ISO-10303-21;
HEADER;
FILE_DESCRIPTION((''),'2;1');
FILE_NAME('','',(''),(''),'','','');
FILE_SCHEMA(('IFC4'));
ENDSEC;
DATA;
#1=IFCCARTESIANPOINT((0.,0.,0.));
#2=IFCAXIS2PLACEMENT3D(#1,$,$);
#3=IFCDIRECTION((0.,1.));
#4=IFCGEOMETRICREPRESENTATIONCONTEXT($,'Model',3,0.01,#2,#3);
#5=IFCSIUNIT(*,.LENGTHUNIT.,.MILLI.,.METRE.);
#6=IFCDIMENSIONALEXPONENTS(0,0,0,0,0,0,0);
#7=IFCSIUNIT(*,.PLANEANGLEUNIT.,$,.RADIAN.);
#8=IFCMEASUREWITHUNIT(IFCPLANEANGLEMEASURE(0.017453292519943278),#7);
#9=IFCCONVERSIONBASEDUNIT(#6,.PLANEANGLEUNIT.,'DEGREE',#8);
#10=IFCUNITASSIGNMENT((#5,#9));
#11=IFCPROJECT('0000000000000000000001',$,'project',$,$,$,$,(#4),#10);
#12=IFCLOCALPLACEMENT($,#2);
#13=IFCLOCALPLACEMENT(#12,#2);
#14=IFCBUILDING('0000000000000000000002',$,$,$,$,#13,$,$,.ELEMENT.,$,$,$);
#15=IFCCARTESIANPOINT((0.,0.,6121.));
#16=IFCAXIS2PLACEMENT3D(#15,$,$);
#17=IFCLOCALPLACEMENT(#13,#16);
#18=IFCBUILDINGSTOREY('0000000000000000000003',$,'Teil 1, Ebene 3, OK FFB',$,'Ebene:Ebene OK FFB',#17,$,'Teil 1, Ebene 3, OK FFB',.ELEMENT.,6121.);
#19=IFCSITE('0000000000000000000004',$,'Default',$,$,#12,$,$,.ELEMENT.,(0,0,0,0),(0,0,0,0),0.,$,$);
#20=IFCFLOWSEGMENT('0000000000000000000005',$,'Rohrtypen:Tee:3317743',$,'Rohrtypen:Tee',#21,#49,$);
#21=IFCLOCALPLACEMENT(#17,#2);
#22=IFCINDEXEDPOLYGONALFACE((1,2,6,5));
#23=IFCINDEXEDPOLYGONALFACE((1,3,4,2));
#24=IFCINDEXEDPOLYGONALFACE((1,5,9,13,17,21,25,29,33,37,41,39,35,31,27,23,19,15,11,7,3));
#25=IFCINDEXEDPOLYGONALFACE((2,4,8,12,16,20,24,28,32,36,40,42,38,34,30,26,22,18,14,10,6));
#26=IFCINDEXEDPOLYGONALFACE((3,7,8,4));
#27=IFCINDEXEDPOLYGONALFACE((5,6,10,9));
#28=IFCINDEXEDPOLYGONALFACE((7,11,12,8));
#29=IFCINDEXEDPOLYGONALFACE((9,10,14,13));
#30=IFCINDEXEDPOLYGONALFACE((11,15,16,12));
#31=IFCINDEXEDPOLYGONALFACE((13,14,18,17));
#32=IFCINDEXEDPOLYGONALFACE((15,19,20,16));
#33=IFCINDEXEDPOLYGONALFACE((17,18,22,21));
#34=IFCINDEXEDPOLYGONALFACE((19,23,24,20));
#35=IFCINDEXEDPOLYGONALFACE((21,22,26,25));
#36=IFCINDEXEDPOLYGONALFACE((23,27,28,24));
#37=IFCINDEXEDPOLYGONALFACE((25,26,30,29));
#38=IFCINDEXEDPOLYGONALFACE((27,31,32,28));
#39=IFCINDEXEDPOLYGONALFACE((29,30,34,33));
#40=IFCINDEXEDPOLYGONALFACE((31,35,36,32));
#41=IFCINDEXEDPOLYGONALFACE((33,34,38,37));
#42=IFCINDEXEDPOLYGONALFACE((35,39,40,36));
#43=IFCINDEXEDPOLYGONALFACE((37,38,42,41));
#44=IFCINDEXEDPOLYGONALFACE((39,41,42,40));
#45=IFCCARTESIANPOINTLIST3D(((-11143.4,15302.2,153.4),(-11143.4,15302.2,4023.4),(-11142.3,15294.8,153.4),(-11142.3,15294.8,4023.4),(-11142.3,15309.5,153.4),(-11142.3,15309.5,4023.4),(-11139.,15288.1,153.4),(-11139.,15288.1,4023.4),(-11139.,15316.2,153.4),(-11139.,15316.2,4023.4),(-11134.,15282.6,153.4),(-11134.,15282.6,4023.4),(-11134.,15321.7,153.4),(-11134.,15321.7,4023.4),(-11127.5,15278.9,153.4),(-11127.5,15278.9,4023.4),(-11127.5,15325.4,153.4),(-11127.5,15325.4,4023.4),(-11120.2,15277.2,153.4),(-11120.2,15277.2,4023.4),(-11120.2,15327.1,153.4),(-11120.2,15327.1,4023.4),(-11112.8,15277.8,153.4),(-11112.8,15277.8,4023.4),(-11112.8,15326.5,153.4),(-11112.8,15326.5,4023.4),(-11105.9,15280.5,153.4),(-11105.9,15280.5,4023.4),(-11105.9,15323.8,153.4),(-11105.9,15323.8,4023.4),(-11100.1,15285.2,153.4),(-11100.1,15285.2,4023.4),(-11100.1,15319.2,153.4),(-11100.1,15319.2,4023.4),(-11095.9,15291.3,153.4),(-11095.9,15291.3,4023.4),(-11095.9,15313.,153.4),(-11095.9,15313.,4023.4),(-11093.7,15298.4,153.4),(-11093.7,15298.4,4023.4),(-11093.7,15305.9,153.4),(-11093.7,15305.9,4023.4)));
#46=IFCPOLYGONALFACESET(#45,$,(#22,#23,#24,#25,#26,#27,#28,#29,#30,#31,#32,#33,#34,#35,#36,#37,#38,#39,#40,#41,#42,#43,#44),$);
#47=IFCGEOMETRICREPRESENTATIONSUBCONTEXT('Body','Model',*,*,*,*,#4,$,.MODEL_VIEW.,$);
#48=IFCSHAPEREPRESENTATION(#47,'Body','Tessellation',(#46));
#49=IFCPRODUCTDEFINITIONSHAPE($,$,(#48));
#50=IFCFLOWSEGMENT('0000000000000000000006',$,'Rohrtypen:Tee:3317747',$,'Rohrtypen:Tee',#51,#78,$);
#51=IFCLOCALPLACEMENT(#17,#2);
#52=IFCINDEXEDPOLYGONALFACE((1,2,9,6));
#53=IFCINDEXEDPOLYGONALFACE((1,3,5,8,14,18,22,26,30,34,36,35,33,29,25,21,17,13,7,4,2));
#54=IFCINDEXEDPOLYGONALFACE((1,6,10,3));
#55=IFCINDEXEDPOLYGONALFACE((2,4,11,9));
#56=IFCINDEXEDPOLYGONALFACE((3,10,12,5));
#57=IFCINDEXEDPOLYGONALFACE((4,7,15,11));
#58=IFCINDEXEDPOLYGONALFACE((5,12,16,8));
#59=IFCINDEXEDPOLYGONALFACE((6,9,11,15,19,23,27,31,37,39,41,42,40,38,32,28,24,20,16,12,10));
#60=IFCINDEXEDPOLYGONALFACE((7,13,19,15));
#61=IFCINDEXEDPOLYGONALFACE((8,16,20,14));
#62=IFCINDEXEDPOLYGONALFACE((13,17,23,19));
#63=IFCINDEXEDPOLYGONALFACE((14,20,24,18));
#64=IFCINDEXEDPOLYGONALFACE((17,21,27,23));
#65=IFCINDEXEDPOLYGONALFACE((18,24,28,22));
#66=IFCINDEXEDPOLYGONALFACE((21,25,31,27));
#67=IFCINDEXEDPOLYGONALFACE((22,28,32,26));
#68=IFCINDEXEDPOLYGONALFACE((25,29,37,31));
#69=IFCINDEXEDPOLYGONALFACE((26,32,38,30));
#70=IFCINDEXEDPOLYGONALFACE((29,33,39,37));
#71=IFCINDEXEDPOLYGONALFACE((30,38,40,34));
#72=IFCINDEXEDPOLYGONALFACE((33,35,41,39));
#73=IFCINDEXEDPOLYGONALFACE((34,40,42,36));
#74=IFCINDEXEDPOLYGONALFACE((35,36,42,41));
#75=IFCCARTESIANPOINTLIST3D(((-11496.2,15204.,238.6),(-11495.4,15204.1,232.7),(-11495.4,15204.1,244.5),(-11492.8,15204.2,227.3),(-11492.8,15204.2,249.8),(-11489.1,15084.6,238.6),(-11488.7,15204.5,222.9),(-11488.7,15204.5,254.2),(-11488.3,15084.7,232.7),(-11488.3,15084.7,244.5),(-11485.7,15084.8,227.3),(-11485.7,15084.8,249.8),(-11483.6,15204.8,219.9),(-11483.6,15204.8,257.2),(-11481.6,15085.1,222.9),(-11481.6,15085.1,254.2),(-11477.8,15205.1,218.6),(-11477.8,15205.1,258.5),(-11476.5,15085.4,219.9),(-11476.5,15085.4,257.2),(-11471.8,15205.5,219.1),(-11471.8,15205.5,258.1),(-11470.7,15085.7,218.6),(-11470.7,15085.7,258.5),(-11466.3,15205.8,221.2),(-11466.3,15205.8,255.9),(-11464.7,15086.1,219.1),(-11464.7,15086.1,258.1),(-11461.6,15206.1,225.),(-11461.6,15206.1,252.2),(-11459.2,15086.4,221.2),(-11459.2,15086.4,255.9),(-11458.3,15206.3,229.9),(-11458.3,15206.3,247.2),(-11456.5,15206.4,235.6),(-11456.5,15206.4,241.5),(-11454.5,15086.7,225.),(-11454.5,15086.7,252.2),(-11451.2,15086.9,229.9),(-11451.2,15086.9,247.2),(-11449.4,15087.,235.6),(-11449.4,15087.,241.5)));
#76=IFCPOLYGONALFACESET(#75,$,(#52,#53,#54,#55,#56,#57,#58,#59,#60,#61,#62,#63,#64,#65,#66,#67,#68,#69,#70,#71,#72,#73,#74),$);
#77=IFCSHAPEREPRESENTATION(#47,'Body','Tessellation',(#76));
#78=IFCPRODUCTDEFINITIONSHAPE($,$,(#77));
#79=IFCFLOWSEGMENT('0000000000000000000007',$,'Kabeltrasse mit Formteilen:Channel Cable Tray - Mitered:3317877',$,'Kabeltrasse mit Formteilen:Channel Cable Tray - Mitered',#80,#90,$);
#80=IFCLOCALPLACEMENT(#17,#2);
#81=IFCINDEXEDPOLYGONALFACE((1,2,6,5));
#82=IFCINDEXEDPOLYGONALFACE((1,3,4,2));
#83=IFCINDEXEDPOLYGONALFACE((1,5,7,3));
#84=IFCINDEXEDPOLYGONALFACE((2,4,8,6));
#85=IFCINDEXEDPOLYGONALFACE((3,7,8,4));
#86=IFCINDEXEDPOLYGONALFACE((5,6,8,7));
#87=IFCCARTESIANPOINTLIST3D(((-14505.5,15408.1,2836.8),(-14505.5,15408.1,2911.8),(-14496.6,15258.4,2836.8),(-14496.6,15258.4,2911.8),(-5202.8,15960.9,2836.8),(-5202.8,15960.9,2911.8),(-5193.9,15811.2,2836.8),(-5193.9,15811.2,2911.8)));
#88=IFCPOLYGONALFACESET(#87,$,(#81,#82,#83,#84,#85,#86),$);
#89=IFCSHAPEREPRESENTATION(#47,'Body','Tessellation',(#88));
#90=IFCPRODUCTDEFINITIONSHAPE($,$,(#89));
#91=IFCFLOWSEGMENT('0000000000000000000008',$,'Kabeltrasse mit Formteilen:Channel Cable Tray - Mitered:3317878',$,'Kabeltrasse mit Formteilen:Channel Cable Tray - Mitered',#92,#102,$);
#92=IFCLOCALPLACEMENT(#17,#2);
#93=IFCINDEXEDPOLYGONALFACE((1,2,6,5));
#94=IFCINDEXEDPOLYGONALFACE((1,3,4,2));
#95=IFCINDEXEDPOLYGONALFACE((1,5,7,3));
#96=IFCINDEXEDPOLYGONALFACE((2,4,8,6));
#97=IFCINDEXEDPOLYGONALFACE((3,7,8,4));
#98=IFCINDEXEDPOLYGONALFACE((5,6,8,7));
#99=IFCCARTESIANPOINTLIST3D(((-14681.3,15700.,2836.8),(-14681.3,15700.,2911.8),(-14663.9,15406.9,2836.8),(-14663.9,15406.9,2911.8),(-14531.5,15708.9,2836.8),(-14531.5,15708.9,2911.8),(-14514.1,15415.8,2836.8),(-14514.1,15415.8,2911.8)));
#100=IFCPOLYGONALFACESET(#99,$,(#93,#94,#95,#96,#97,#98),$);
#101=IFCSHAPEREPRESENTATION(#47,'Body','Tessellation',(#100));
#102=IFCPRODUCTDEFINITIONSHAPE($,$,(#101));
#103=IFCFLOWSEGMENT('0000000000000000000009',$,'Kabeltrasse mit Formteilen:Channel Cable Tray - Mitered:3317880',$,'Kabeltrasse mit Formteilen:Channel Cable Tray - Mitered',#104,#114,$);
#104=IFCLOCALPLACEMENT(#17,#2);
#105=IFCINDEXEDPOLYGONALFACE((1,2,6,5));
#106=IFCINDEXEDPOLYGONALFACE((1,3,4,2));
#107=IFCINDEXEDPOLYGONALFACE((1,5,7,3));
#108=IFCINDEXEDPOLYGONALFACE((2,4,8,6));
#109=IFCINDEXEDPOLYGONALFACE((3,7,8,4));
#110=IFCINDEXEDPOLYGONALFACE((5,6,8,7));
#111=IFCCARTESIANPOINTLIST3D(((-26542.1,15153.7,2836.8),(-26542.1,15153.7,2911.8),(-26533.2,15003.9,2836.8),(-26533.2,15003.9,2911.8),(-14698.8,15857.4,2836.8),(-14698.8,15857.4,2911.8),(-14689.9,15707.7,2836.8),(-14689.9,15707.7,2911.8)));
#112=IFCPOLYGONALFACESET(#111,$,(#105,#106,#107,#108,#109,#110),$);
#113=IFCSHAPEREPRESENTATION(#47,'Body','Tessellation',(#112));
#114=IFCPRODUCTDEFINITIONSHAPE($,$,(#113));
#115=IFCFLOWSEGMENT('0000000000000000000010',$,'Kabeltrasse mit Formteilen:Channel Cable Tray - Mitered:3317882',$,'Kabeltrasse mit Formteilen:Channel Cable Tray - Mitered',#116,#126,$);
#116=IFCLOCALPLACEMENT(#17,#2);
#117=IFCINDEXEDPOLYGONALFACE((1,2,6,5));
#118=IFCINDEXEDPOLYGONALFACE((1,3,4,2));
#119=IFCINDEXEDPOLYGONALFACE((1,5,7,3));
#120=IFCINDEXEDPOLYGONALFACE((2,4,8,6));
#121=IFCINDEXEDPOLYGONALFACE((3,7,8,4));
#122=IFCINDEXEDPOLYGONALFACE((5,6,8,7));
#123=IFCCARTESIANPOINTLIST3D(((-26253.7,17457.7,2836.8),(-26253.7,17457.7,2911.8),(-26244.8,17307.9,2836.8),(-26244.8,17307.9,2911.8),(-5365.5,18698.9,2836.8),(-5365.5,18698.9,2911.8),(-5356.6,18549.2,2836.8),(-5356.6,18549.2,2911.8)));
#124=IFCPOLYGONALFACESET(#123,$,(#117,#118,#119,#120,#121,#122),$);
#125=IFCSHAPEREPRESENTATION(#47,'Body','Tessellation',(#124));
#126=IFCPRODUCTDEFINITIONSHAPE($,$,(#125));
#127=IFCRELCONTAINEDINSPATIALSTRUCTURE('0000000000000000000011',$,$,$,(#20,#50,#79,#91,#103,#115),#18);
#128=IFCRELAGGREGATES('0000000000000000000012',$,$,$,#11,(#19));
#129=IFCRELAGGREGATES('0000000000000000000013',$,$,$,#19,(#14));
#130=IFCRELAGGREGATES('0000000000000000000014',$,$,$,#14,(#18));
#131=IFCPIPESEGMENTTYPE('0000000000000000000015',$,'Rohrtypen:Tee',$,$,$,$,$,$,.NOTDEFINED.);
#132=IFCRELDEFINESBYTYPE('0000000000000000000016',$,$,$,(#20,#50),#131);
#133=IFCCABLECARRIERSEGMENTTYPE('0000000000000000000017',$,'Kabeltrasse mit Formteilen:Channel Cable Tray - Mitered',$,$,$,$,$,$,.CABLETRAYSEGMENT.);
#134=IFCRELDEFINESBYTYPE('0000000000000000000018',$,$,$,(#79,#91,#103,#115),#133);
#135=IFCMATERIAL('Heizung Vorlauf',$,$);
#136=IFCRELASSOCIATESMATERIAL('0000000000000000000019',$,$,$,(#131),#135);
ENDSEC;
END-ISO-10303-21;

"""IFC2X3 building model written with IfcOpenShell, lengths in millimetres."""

from ifc_helpers import new_model, entity, si_unit, converted_unit, direction, frame, frame_2d, origin, origin_2d_with_axis, place, context, subcontext, project, spatial, rectangle, circle, extrude, material, type_object, element, save


model = new_model("IFC2X3")

# Units and contexts
model_context = context("Model", 3, precision=0.01, world=origin(), true_north=direction((0.0, 1.0)))
body_context = subcontext(model_context, "Body", "Model", "MODEL_VIEW")
ifc_project = project(units=[si_unit("LENGTHUNIT", "METRE", prefix="MILLI"), converted_unit("PLANEANGLEUNIT", "DEGREE", entity("IfcPlaneAngleMeasure", 0.017453292519943278), si_unit("PLANEANGLEUNIT", "RADIAN"), dimensions=[0, 0, 0, 0, 0, 0, 0])], contexts=[model_context])

# Site, building, storey
site_placement = place(None, origin())
site = spatial("IfcSite", under=ifc_project, at=site_placement, Name="Default", CompositionType="ELEMENT", RefLatitude=(0, 0, 0, 0), RefLongitude=(0, 0, 0, 0), RefElevation=0.0)
building_placement = place(site_placement, origin())
building = spatial("IfcBuilding", under=site, at=building_placement, CompositionType="ELEMENT")
storey_placement = place(building_placement, frame((0.0, 0.0, 6121.0)))
storey = spatial("IfcBuildingStorey", under=building, at=storey_placement, Name="Teil 1, Ebene 3, OK FFB", ObjectType="Ebene:Ebene OK FFB", LongName="Teil 1, Ebene 3, OK FFB", CompositionType="ELEMENT", Elevation=6121.0)

# Flow segments
ifc_material = material(Name="Heizung Vorlauf")
pipe_segment_type = type_object("IfcPipeSegmentType", Name="Rohrtypen:Tee", PredefinedType="NOTDEFINED", material=ifc_material)
flow_segment_1_placement = place(storey_placement, origin())
element("IfcFlowSegment", 1, at=flow_segment_1_placement, inside=storey, type_object=pipe_segment_type, Name="Rohrtypen:Tee:3317743", ObjectType="Rohrtypen:Tee", context=body_context, shape_type="SweptSolid", body=[
    extrude(circle(Radius=25.0, at=frame_2d((0.0, 0.0), x_axis=(1.0, 0.0))), frame((-11118.4, 15302.2, 153.4), z_axis=(0.0, 0.0, 1.0), x_axis=(-1.0, 0.0, 0.0)), (0.0, 0.0, 1.0), 3870.0),
])
flow_segment_2_placement = place(storey_placement, origin())
element("IfcFlowSegment", 2, at=flow_segment_2_placement, inside=storey, type_object=pipe_segment_type, Name="Rohrtypen:Tee:3317747", ObjectType="Rohrtypen:Tee", context=body_context, shape_type="SweptSolid", body=[
    extrude(circle(Radius=20.0, at=origin_2d_with_axis()), frame((-11476.3, 15205.2, 238.6), z_axis=(0.059319, -0.998239, 0.0), x_axis=(-0.998239, -0.059319, 0.0)), (0.0, 0.0, 1.0), 119.6),
])
cable_carrier_segment_type = type_object("IfcCableCarrierSegmentType", Name="Kabeltrasse mit Formteilen:Channel Cable Tray - Mitered", PredefinedType="CABLETRAYSEGMENT")
flow_segment_3_placement = place(storey_placement, origin())
element("IfcFlowSegment", 3, at=flow_segment_3_placement, inside=storey, type_object=cable_carrier_segment_type, Name="Kabeltrasse mit Formteilen:Channel Cable Tray - Mitered:3317877", ObjectType="Kabeltrasse mit Formteilen:Channel Cable Tray - Mitered", context=body_context, shape_type="SweptSolid", body=[
    extrude(rectangle(XDim=9319.1, YDim=150.0, at=frame_2d((0.0, 0.0), x_axis=(1.0, 0.0))), frame((-9849.7, 15609.7, 2836.8), z_axis=(0.0, 0.0, 1.0), x_axis=(-0.998239, -0.059319, 0.0)), (0.0, 0.0, 1.0), 75.0),
])
flow_segment_4_placement = place(storey_placement, origin())
element("IfcFlowSegment", 4, at=flow_segment_4_placement, inside=storey, type_object=cable_carrier_segment_type, Name="Kabeltrasse mit Formteilen:Channel Cable Tray - Mitered:3317878", ObjectType="Kabeltrasse mit Formteilen:Channel Cable Tray - Mitered", context=body_context, shape_type="SweptSolid", body=[
    extrude(rectangle(XDim=293.7, YDim=150.0, at=frame_2d((0.0, 0.0), x_axis=(1.0, 0.0))), frame((-14597.7, 15557.9, 2836.8), z_axis=(0.0, 0.0, 1.0), x_axis=(-0.059319, 0.998239, 0.0)), (0.0, 0.0, 1.0), 75.0),
])
flow_segment_5_placement = place(storey_placement, origin())
element("IfcFlowSegment", 5, at=flow_segment_5_placement, inside=storey, type_object=cable_carrier_segment_type, Name="Kabeltrasse mit Formteilen:Channel Cable Tray - Mitered:3317880", ObjectType="Kabeltrasse mit Formteilen:Channel Cable Tray - Mitered", context=body_context, shape_type="SweptSolid", body=[
    extrude(rectangle(XDim=11864.2, YDim=150.0, at=frame_2d((0.0, 0.0), x_axis=(1.0, 0.0))), frame((-20616.0, 15430.7, 2836.8), z_axis=(0.0, 0.0, 1.0), x_axis=(-0.998239, -0.059319, 0.0)), (0.0, 0.0, 1.0), 75.0),
])
flow_segment_6_placement = place(storey_placement, origin())
element("IfcFlowSegment", 6, at=flow_segment_6_placement, inside=storey, type_object=cable_carrier_segment_type, Name="Kabeltrasse mit Formteilen:Channel Cable Tray - Mitered:3317882", ObjectType="Kabeltrasse mit Formteilen:Channel Cable Tray - Mitered", context=body_context, shape_type="SweptSolid", body=[
    extrude(rectangle(XDim=20925.0, YDim=150.0, at=frame_2d((0.0, 0.0), x_axis=(1.0, 0.0))), frame((-15805.1, 18003.4, 2836.8), z_axis=(0.0, 0.0, 1.0), x_axis=(-0.998239, -0.059319, 0.0)), (0.0, 0.0, 1.0), 75.0),
])

save(model, "model.ifc")
